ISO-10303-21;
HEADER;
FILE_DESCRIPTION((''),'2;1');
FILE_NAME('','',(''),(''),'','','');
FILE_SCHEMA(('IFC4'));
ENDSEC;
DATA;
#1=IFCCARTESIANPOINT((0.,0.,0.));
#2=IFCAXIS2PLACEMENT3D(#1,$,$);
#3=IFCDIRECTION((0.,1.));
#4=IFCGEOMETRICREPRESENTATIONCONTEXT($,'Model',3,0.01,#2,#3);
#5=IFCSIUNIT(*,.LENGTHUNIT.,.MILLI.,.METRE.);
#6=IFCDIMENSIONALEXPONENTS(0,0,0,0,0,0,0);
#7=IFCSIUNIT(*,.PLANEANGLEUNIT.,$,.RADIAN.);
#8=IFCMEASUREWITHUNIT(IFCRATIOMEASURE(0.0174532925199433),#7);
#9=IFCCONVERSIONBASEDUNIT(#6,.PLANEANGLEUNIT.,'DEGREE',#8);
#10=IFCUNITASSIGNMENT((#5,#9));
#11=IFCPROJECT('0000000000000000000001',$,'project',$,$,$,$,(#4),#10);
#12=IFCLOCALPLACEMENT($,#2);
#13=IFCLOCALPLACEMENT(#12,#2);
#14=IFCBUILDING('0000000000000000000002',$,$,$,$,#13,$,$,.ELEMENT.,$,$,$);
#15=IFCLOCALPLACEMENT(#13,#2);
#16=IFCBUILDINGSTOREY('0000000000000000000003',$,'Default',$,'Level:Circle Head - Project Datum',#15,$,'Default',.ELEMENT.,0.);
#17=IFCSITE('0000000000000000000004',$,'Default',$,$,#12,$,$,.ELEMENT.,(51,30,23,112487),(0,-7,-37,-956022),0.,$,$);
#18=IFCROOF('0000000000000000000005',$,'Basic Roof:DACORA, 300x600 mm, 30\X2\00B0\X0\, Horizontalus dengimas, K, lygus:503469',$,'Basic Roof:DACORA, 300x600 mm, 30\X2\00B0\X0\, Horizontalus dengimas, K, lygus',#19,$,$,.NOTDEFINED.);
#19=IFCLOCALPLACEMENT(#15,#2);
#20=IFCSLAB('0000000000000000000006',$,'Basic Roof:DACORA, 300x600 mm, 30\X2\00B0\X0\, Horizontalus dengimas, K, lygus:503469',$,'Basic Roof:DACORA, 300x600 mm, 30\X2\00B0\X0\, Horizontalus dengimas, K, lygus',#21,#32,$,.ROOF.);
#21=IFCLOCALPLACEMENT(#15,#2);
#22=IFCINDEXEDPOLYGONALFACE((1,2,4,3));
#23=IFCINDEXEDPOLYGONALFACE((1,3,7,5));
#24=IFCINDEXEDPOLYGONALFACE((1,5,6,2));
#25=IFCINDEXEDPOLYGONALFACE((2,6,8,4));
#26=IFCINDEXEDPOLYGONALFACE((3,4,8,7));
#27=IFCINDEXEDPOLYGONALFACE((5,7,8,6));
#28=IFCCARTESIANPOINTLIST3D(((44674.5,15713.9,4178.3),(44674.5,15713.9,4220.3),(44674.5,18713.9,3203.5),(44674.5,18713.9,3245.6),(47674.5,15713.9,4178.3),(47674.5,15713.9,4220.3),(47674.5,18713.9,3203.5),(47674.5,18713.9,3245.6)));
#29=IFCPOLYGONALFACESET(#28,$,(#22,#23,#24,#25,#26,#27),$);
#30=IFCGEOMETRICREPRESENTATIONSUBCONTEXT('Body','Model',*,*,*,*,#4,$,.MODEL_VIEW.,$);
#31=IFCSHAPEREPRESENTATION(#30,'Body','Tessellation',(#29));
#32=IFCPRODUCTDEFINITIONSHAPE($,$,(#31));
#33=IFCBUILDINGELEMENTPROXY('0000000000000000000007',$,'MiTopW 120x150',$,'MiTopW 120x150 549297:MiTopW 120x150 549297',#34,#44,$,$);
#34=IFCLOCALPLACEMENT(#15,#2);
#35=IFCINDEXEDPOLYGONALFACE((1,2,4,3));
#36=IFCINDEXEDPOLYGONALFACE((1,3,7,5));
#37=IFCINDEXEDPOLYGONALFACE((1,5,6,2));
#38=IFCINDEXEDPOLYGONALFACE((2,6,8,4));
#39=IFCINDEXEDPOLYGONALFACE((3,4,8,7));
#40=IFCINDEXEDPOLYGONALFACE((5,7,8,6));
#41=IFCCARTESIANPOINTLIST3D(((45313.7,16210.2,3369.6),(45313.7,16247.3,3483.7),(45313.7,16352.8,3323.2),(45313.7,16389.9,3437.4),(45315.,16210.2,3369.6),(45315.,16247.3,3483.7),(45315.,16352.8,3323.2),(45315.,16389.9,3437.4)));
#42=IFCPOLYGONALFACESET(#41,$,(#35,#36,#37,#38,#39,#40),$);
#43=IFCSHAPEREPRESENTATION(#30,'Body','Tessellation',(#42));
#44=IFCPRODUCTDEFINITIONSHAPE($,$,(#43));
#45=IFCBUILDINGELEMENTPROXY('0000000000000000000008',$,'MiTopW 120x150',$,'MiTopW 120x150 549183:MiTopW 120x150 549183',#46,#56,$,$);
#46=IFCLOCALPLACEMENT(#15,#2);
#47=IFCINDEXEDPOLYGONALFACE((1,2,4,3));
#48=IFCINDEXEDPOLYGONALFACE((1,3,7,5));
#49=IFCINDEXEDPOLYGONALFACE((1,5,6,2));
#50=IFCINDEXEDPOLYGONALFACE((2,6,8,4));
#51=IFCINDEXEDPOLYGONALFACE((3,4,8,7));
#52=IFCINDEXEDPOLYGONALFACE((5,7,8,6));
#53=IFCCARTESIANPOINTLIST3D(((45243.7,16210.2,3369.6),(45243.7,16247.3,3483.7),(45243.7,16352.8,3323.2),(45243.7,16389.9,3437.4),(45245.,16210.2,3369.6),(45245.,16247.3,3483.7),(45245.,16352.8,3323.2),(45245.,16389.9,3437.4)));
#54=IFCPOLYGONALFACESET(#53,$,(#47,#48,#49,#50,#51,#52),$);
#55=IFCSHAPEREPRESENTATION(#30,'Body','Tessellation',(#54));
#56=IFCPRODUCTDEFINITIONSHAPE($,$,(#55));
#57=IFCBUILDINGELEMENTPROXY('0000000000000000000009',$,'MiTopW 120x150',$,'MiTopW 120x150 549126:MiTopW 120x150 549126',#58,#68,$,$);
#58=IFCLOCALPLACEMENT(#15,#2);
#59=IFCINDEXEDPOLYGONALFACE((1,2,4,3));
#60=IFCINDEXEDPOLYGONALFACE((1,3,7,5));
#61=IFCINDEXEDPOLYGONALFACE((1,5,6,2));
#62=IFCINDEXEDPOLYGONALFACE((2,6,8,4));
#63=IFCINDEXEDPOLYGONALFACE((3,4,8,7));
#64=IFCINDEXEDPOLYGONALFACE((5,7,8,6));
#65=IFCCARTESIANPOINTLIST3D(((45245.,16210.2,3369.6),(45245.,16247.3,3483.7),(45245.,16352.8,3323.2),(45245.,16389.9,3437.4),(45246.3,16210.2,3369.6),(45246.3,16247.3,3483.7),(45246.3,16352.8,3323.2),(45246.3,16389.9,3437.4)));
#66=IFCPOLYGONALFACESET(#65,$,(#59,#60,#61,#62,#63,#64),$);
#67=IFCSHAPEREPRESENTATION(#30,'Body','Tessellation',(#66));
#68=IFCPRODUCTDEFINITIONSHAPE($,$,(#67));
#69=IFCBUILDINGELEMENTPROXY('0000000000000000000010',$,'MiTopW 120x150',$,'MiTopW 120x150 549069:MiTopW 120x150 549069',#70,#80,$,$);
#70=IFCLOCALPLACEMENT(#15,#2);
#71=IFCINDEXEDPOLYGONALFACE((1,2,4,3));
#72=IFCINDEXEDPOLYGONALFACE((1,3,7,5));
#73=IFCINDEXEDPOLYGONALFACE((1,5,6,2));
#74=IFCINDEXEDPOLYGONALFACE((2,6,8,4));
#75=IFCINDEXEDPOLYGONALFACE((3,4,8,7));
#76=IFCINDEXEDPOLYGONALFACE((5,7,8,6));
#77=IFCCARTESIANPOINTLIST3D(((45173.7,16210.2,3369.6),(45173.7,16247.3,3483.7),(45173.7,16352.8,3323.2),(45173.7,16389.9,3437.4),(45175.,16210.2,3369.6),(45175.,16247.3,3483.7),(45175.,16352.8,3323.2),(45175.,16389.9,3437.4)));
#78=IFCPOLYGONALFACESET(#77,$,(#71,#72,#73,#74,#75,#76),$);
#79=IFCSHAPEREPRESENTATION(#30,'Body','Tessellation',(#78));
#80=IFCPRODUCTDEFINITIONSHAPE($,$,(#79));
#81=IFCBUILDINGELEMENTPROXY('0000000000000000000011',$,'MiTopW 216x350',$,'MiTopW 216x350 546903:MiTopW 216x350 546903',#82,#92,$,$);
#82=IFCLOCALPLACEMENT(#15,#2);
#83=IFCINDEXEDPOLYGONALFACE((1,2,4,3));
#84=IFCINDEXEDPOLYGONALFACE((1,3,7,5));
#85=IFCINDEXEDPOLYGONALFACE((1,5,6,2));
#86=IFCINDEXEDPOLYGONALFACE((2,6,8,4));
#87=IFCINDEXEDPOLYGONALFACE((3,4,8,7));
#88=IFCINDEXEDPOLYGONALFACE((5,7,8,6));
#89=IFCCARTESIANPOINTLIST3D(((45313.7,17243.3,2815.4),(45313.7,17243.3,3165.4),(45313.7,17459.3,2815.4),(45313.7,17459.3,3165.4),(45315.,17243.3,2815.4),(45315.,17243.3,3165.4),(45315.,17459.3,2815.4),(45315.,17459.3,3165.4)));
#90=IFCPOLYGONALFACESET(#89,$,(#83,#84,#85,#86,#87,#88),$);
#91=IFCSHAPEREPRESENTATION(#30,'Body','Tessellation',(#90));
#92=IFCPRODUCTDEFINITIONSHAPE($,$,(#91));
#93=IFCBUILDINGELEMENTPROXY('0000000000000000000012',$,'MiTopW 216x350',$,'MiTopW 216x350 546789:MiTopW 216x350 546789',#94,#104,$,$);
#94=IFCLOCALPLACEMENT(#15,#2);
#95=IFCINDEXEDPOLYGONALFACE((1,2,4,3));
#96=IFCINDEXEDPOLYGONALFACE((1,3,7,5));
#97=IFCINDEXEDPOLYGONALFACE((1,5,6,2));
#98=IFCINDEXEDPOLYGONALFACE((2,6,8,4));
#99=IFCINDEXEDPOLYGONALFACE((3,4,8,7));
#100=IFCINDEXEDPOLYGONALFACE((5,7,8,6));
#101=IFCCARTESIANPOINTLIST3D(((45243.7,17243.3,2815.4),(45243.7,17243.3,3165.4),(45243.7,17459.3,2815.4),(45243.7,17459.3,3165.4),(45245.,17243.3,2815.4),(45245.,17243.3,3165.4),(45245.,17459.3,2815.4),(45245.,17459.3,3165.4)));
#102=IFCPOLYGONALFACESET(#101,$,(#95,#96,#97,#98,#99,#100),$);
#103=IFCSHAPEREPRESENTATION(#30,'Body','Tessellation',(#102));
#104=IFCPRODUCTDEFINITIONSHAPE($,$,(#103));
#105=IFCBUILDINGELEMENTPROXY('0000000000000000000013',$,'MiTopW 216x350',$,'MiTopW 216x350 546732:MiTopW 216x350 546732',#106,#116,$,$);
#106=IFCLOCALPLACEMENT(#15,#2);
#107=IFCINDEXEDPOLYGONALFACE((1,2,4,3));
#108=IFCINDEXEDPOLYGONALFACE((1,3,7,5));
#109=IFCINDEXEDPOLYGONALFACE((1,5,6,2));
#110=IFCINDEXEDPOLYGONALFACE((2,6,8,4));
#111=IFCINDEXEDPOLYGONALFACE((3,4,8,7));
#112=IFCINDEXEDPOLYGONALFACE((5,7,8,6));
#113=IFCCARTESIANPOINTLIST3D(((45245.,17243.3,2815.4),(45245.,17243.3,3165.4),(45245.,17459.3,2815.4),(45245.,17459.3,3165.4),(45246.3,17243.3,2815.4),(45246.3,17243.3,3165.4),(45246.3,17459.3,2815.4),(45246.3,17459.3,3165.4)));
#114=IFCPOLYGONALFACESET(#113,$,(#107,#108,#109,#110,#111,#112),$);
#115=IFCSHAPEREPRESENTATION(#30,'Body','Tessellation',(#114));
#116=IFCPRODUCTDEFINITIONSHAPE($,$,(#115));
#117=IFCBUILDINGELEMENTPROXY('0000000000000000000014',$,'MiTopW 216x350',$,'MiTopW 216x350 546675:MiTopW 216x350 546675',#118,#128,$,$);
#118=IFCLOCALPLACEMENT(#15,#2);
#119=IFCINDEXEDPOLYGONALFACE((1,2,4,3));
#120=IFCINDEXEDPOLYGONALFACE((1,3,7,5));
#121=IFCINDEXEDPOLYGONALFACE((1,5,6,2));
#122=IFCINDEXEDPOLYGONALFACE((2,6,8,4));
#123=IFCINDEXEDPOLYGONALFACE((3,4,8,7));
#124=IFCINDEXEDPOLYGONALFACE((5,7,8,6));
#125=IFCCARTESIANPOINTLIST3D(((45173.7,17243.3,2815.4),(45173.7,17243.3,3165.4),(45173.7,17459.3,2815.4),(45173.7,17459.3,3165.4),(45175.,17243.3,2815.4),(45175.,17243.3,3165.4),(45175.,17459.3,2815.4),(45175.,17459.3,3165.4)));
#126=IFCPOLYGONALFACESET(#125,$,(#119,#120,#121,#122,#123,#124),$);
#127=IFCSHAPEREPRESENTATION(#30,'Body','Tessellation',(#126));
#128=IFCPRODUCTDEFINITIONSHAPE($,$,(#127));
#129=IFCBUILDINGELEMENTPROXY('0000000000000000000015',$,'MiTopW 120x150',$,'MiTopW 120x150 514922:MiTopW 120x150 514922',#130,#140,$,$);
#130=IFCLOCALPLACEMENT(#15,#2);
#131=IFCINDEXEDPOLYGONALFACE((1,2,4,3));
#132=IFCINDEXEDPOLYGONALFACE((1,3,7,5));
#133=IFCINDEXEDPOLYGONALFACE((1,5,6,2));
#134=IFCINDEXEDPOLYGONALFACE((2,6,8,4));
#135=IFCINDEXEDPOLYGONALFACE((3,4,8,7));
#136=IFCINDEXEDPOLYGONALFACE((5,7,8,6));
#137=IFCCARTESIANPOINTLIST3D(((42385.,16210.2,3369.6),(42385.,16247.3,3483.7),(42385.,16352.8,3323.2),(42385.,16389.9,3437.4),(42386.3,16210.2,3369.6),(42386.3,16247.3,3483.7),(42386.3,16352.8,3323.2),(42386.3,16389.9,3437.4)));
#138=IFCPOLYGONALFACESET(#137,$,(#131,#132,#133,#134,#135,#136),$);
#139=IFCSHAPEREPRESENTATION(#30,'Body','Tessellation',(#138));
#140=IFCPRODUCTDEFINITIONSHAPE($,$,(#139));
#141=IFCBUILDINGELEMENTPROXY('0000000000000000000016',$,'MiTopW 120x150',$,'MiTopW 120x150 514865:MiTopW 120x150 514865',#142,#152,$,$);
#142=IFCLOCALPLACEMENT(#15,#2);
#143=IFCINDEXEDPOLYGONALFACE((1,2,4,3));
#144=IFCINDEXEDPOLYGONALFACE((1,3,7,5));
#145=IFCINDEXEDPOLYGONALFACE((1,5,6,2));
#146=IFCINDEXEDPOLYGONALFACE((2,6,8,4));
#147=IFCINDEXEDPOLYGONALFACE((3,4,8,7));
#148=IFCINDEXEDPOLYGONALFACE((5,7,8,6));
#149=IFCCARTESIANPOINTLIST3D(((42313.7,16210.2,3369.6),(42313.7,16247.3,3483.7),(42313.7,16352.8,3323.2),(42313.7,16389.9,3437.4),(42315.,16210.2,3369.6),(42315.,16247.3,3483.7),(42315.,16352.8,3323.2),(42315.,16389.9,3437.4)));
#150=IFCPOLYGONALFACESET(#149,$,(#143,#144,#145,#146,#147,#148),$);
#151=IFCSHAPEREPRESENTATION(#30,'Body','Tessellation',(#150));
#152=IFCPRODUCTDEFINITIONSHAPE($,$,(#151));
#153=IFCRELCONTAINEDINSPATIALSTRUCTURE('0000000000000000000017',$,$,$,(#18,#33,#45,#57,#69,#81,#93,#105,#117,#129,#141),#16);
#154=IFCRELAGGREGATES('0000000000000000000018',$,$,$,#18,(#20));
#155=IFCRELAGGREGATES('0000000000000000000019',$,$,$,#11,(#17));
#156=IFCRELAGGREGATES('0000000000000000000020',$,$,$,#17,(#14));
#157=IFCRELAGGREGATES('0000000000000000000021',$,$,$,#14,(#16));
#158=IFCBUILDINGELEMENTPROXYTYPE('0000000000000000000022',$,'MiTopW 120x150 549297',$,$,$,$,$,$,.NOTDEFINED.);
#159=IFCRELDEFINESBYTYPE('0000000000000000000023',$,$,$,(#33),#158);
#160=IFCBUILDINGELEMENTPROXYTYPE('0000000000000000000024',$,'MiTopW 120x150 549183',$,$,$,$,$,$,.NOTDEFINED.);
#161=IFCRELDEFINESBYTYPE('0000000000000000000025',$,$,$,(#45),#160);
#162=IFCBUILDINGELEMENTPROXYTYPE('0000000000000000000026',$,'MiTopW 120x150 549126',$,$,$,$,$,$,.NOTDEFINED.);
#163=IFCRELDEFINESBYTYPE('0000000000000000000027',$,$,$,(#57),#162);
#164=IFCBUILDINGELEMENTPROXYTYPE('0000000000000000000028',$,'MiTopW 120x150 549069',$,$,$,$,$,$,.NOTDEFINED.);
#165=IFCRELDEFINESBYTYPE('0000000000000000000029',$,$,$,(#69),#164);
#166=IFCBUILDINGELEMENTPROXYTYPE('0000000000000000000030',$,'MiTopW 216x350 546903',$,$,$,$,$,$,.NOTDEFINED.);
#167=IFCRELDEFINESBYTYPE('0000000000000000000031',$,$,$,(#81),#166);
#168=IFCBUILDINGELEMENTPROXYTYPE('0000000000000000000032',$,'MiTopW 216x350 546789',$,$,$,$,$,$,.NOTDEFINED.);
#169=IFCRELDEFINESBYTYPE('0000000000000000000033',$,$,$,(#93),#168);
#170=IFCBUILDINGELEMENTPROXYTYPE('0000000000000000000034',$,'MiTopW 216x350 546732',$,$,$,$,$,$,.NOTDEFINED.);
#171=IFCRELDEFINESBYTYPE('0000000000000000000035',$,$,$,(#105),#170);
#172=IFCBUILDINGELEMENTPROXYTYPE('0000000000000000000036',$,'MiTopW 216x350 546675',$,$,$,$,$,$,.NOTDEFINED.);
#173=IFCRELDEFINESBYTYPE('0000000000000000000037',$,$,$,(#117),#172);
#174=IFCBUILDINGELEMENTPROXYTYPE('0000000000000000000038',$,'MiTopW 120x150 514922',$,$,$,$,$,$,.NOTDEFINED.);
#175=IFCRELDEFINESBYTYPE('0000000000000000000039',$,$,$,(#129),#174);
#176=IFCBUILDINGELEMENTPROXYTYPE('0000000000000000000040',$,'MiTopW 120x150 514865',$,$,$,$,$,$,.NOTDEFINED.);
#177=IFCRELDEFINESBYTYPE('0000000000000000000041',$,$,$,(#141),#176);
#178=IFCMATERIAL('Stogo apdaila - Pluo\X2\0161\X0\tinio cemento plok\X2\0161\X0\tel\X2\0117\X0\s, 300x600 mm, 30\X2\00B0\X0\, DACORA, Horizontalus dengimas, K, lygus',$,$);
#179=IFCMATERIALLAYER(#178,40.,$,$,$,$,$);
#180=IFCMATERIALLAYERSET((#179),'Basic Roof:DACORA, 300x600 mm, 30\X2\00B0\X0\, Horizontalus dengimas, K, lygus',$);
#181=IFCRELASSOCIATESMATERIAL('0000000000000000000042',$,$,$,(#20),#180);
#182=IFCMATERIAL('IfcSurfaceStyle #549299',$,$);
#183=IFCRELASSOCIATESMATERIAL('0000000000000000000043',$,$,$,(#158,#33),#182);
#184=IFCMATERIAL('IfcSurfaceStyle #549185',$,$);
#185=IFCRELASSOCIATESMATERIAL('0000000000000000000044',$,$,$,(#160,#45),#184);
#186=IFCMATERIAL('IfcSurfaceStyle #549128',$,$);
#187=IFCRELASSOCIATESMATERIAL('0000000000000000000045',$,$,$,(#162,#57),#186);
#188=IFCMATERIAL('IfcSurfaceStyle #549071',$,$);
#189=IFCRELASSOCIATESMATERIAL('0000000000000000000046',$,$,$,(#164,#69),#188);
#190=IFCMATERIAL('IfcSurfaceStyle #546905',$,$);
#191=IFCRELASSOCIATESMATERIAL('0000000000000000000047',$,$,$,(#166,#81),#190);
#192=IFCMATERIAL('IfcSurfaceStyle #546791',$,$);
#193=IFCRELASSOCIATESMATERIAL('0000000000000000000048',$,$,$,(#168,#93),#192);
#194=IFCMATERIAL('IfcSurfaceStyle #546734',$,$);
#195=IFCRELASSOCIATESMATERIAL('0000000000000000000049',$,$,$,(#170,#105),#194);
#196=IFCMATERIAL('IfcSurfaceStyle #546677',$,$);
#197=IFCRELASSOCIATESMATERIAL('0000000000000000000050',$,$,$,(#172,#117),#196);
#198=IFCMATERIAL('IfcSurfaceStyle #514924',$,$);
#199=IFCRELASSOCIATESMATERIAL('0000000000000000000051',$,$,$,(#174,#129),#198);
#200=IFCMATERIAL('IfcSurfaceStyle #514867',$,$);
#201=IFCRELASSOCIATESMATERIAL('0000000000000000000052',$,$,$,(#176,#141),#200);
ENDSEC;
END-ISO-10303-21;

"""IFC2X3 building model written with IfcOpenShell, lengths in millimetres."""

from ifc_helpers import new_model, entity, si_unit, converted_unit, direction, frame, frame_2d, origin, origin_2d_with_axis, place, context, subcontext, project, spatial, polyline, rectangle, outline, extrude, source, transform, mapped, material, layer, layer_set, type_object, type_shapes, element, aggregate, save


model = new_model("IFC2X3")

# Units and contexts
model_context = context("Model", 3, precision=0.01, world=origin(), true_north=direction((0.0, 1.0)))
body_context = subcontext(model_context, "Body", "Model", "MODEL_VIEW")
ifc_project = project(units=[si_unit("LENGTHUNIT", "METRE", prefix="MILLI"), converted_unit("PLANEANGLEUNIT", "DEGREE", entity("IfcRatioMeasure", 0.0174532925199433), si_unit("PLANEANGLEUNIT", "RADIAN"), dimensions=[0, 0, 0, 0, 0, 0, 0])], contexts=[model_context])

# Site, building, storey
site_placement = place(None, origin())
site = spatial("IfcSite", under=ifc_project, at=site_placement, Name="Default", CompositionType="ELEMENT", RefLatitude=(51, 30, 23, 112487), RefLongitude=(0, -7, -37, -956022), RefElevation=0.0)
building_placement = place(site_placement, origin())
building = spatial("IfcBuilding", under=site, at=building_placement, CompositionType="ELEMENT")
storey_placement = place(building_placement, origin())
storey = spatial("IfcBuildingStorey", under=building, at=storey_placement, Name="Default", ObjectType="Level:Circle Head - Project Datum", LongName="Default", CompositionType="ELEMENT", Elevation=0.0)

# Roof, slab
roof_placement = place(storey_placement, frame((44674.5, 15713.9, 3203.5)))
roof = element("IfcRoof", 1, at=roof_placement, inside=storey, Name="Basic Roof:DACORA, 300x600 mm, 30°, Horizontalus dengimas, K, lygus:503469", ObjectType="Basic Roof:DACORA, 300x600 mm, 30°, Horizontalus dengimas, K, lygus", ShapeType="NOTDEFINED")
ifc_material_1 = material(Name="Stogo apdaila - Pluoštinio cemento plokštelės, 300x600 mm, 30°, DACORA, Horizontalus dengimas, K, lygus")
ifc_layer = layer(ifc_material_1, 40.0)
ifc_layer_set = layer_set([ifc_layer], Name="Basic Roof:DACORA, 300x600 mm, 30°, Horizontalus dengimas, K, lygus")
slab_placement = place(roof_placement, origin())
slab = element("IfcSlab", 2, at=slab_placement, material=ifc_layer_set, Name="Basic Roof:DACORA, 300x600 mm, 30°, Horizontalus dengimas, K, lygus:503469", ObjectType="Basic Roof:DACORA, 300x600 mm, 30°, Horizontalus dengimas, K, lygus", PredefinedType="ROOF", context=body_context, shape_type="SweptSolid", body=[
    extrude(rectangle(XDim=3154.4, YDim=3000.0, at=frame_2d((0.0, 0.0), x_axis=(0.0, 1.0))), frame((1500.0, 1500.0, 487.4), z_axis=(0.0, 0.309017, 0.951057), x_axis=(1.0, 0.0, 0.0)), (0.0, -0.309017, 0.951057), 42.1),
])
aggregate(roof, [slab])

# Building element proxies
ifc_material_2 = material(Name="IfcSurfaceStyle #549299")
building_element_proxy_type_1 = type_object("IfcBuildingElementProxyType", Name="MiTopW 120x150 549297", PredefinedType="NOTDEFINED", material=ifc_material_2)
shared_shape_1 = source(origin(), body_context, "Body", "SweptSolid", [
    extrude(outline(polyline([(-75.0, -60.0), (75.0, -60.0), (75.0, 60.0), (-75.0, 60.0), (-75.0, -60.0)])), frame((75.0, 60.0, 0.0), z_axis=(0.0, 0.0, 1.0), x_axis=(-1.0, 0.0, 0.0)), (0.0, 0.0, 1.0), 1.3),
])
type_shapes(building_element_proxy_type_1, [shared_shape_1])
proxy_1_placement = place(building_placement, frame((45315.0, 16352.8, 3323.2), z_axis=(-1.0, 0.0, 0.0), x_axis=(0.0, -0.951057, 0.309017)))
element("IfcBuildingElementProxy", 3, at=proxy_1_placement, inside=storey, type_object=building_element_proxy_type_1, material=ifc_material_2, Name="MiTopW 120x150", ObjectType="MiTopW 120x150 549297:MiTopW 120x150 549297", context=body_context, shape_type="MappedRepresentation", body=[
    mapped(shared_shape_1, transform((0.0, 0.0, 0.0), scale=1.0)),
])
ifc_material_3 = material(Name="IfcSurfaceStyle #549185")
building_element_proxy_type_2 = type_object("IfcBuildingElementProxyType", Name="MiTopW 120x150 549183", PredefinedType="NOTDEFINED", material=ifc_material_3)
shared_shape_2 = source(origin(), body_context, "Body", "SweptSolid", [
    extrude(outline(polyline([(-75.0, -60.0), (75.0, -60.0), (75.0, 60.0), (-75.0, 60.0), (-75.0, -60.0)])), frame((75.0, 60.0, 0.0), z_axis=(0.0, 0.0, 1.0), x_axis=(-1.0, 0.0, 0.0)), (0.0, 0.0, 1.0), 1.3),
])
type_shapes(building_element_proxy_type_2, [shared_shape_2])
proxy_2_placement = place(building_placement, frame((45245.0, 16352.8, 3323.2), z_axis=(-1.0, 0.0, 0.0), x_axis=(0.0, -0.951057, 0.309017)))
element("IfcBuildingElementProxy", 4, at=proxy_2_placement, inside=storey, type_object=building_element_proxy_type_2, material=ifc_material_3, Name="MiTopW 120x150", ObjectType="MiTopW 120x150 549183:MiTopW 120x150 549183", context=body_context, shape_type="MappedRepresentation", body=[
    mapped(shared_shape_2, transform((0.0, 0.0, 0.0), scale=1.0)),
])
ifc_material_4 = material(Name="IfcSurfaceStyle #549128")
building_element_proxy_type_3 = type_object("IfcBuildingElementProxyType", Name="MiTopW 120x150 549126", PredefinedType="NOTDEFINED", material=ifc_material_4)
shared_shape_3 = source(origin(), body_context, "Body", "SweptSolid", [
    extrude(outline(polyline([(-75.0, -60.0), (75.0, -60.0), (75.0, 60.0), (-75.0, 60.0), (-75.0, -60.0)])), frame((75.0, 60.0, 0.0), z_axis=(0.0, 0.0, 1.0), x_axis=(-1.0, 0.0, 0.0)), (0.0, 0.0, 1.0), 1.3),
])
type_shapes(building_element_proxy_type_3, [shared_shape_3])
proxy_3_placement = place(building_placement, frame((45246.3, 16352.8, 3323.2), z_axis=(-1.0, 0.0, 0.0), x_axis=(0.0, -0.951057, 0.309017)))
element("IfcBuildingElementProxy", 5, at=proxy_3_placement, inside=storey, type_object=building_element_proxy_type_3, material=ifc_material_4, Name="MiTopW 120x150", ObjectType="MiTopW 120x150 549126:MiTopW 120x150 549126", context=body_context, shape_type="MappedRepresentation", body=[
    mapped(shared_shape_3, transform((0.0, 0.0, 0.0), scale=1.0)),
])
ifc_material_5 = material(Name="IfcSurfaceStyle #549071")
building_element_proxy_type_4 = type_object("IfcBuildingElementProxyType", Name="MiTopW 120x150 549069", PredefinedType="NOTDEFINED", material=ifc_material_5)
shared_shape_4 = source(origin(), body_context, "Body", "SweptSolid", [
    extrude(outline(polyline([(-75.0, -60.0), (75.0, -60.0), (75.0, 60.0), (-75.0, 60.0), (-75.0, -60.0)])), frame((75.0, 60.0, 0.0), z_axis=(0.0, 0.0, 1.0), x_axis=(-1.0, 0.0, 0.0)), (0.0, 0.0, 1.0), 1.3),
])
type_shapes(building_element_proxy_type_4, [shared_shape_4])
proxy_4_placement = place(building_placement, frame((45175.0, 16352.8, 3323.2), z_axis=(-1.0, 0.0, 0.0), x_axis=(0.0, -0.951057, 0.309017)))
element("IfcBuildingElementProxy", 6, at=proxy_4_placement, inside=storey, type_object=building_element_proxy_type_4, material=ifc_material_5, Name="MiTopW 120x150", ObjectType="MiTopW 120x150 549069:MiTopW 120x150 549069", context=body_context, shape_type="MappedRepresentation", body=[
    mapped(shared_shape_4, transform((0.0, 0.0, 0.0), scale=1.0)),
])
ifc_material_6 = material(Name="IfcSurfaceStyle #546905")
building_element_proxy_type_5 = type_object("IfcBuildingElementProxyType", Name="MiTopW 216x350 546903", PredefinedType="NOTDEFINED", material=ifc_material_6)
shared_shape_5 = source(origin(), body_context, "Body", "SweptSolid", [
    extrude(rectangle(XDim=350.0, YDim=216.0, at=origin_2d_with_axis()), frame((175.0, 108.0, 0.0), z_axis=(0.0, 0.0, 1.0), x_axis=(-1.0, 0.0, 0.0)), (0.0, 0.0, 1.0), 1.3),
])
type_shapes(building_element_proxy_type_5, [shared_shape_5])
proxy_5_placement = place(building_placement, frame((45315.0, 17459.3, 3165.4), z_axis=(-1.0, 0.0, 0.0), x_axis=(0.0, 0.0, -1.0)))
element("IfcBuildingElementProxy", 7, at=proxy_5_placement, inside=storey, type_object=building_element_proxy_type_5, material=ifc_material_6, Name="MiTopW 216x350", ObjectType="MiTopW 216x350 546903:MiTopW 216x350 546903", context=body_context, shape_type="MappedRepresentation", body=[
    mapped(shared_shape_5, transform((0.0, 0.0, 0.0), scale=1.0)),
])
ifc_material_7 = material(Name="IfcSurfaceStyle #546791")
building_element_proxy_type_6 = type_object("IfcBuildingElementProxyType", Name="MiTopW 216x350 546789", PredefinedType="NOTDEFINED", material=ifc_material_7)
shared_shape_6 = source(origin(), body_context, "Body", "SweptSolid", [
    extrude(rectangle(XDim=350.0, YDim=216.0, at=origin_2d_with_axis()), frame((175.0, 108.0, 0.0), z_axis=(0.0, 0.0, 1.0), x_axis=(-1.0, 0.0, 0.0)), (0.0, 0.0, 1.0), 1.3),
])
type_shapes(building_element_proxy_type_6, [shared_shape_6])
proxy_6_placement = place(building_placement, frame((45245.0, 17459.3, 3165.4), z_axis=(-1.0, 0.0, 0.0), x_axis=(0.0, 0.0, -1.0)))
element("IfcBuildingElementProxy", 8, at=proxy_6_placement, inside=storey, type_object=building_element_proxy_type_6, material=ifc_material_7, Name="MiTopW 216x350", ObjectType="MiTopW 216x350 546789:MiTopW 216x350 546789", context=body_context, shape_type="MappedRepresentation", body=[
    mapped(shared_shape_6, transform((0.0, 0.0, 0.0), scale=1.0)),
])
ifc_material_8 = material(Name="IfcSurfaceStyle #546734")
building_element_proxy_type_7 = type_object("IfcBuildingElementProxyType", Name="MiTopW 216x350 546732", PredefinedType="NOTDEFINED", material=ifc_material_8)
shared_shape_7 = source(origin(), body_context, "Body", "SweptSolid", [
    extrude(rectangle(XDim=350.0, YDim=216.0, at=origin_2d_with_axis()), frame((175.0, 108.0, 0.0), z_axis=(0.0, 0.0, 1.0), x_axis=(-1.0, 0.0, 0.0)), (0.0, 0.0, 1.0), 1.3),
])
type_shapes(building_element_proxy_type_7, [shared_shape_7])
proxy_7_placement = place(building_placement, frame((45246.3, 17459.3, 3165.4), z_axis=(-1.0, 0.0, 0.0), x_axis=(0.0, 0.0, -1.0)))
element("IfcBuildingElementProxy", 9, at=proxy_7_placement, inside=storey, type_object=building_element_proxy_type_7, material=ifc_material_8, Name="MiTopW 216x350", ObjectType="MiTopW 216x350 546732:MiTopW 216x350 546732", context=body_context, shape_type="MappedRepresentation", body=[
    mapped(shared_shape_7, transform((0.0, 0.0, 0.0), scale=1.0)),
])
ifc_material_9 = material(Name="IfcSurfaceStyle #546677")
building_element_proxy_type_8 = type_object("IfcBuildingElementProxyType", Name="MiTopW 216x350 546675", PredefinedType="NOTDEFINED", material=ifc_material_9)
shared_shape_8 = source(origin(), body_context, "Body", "SweptSolid", [
    extrude(rectangle(XDim=350.0, YDim=216.0, at=origin_2d_with_axis()), frame((175.0, 108.0, 0.0), z_axis=(0.0, 0.0, 1.0), x_axis=(-1.0, 0.0, 0.0)), (0.0, 0.0, 1.0), 1.3),
])
type_shapes(building_element_proxy_type_8, [shared_shape_8])
proxy_8_placement = place(building_placement, frame((45175.0, 17459.3, 3165.4), z_axis=(-1.0, 0.0, 0.0), x_axis=(0.0, 0.0, -1.0)))
element("IfcBuildingElementProxy", 10, at=proxy_8_placement, inside=storey, type_object=building_element_proxy_type_8, material=ifc_material_9, Name="MiTopW 216x350", ObjectType="MiTopW 216x350 546675:MiTopW 216x350 546675", context=body_context, shape_type="MappedRepresentation", body=[
    mapped(shared_shape_8, transform((0.0, 0.0, 0.0), scale=1.0)),
])
ifc_material_10 = material(Name="IfcSurfaceStyle #514924")
building_element_proxy_type_9 = type_object("IfcBuildingElementProxyType", Name="MiTopW 120x150 514922", PredefinedType="NOTDEFINED", material=ifc_material_10)
shared_shape_9 = source(origin(), body_context, "Body", "SweptSolid", [
    extrude(outline(polyline([(-75.0, -60.0), (75.0, -60.0), (75.0, 60.0), (-75.0, 60.0), (-75.0, -60.0)])), frame((75.0, 60.0, 0.0), z_axis=(0.0, 0.0, 1.0), x_axis=(-1.0, 0.0, 0.0)), (0.0, 0.0, 1.0), 1.3),
])
type_shapes(building_element_proxy_type_9, [shared_shape_9])
proxy_9_placement = place(building_placement, frame((42386.3, 16352.8, 3323.2), z_axis=(-1.0, 0.0, 0.0), x_axis=(0.0, -0.951057, 0.309017)))
element("IfcBuildingElementProxy", 11, at=proxy_9_placement, inside=storey, type_object=building_element_proxy_type_9, material=ifc_material_10, Name="MiTopW 120x150", ObjectType="MiTopW 120x150 514922:MiTopW 120x150 514922", context=body_context, shape_type="MappedRepresentation", body=[
    mapped(shared_shape_9, transform((0.0, 0.0, 0.0), scale=1.0)),
])
ifc_material_11 = material(Name="IfcSurfaceStyle #514867")
building_element_proxy_type_10 = type_object("IfcBuildingElementProxyType", Name="MiTopW 120x150 514865", PredefinedType="NOTDEFINED", material=ifc_material_11)
shared_shape_10 = source(origin(), body_context, "Body", "SweptSolid", [
    extrude(outline(polyline([(-75.0, -60.0), (75.0, -60.0), (75.0, 60.0), (-75.0, 60.0), (-75.0, -60.0)])), frame((75.0, 60.0, 0.0), z_axis=(0.0, 0.0, 1.0), x_axis=(-1.0, 0.0, 0.0)), (0.0, 0.0, 1.0), 1.3),
])
type_shapes(building_element_proxy_type_10, [shared_shape_10])
proxy_10_placement = place(building_placement, frame((42315.0, 16352.8, 3323.2), z_axis=(-1.0, 0.0, 0.0), x_axis=(0.0, -0.951057, 0.309017)))
element("IfcBuildingElementProxy", 12, at=proxy_10_placement, inside=storey, type_object=building_element_proxy_type_10, material=ifc_material_11, Name="MiTopW 120x150", ObjectType="MiTopW 120x150 514865:MiTopW 120x150 514865", context=body_context, shape_type="MappedRepresentation", body=[
    mapped(shared_shape_10, transform((0.0, 0.0, 0.0), scale=1.0)),
])

save(model, "model.ifc")
